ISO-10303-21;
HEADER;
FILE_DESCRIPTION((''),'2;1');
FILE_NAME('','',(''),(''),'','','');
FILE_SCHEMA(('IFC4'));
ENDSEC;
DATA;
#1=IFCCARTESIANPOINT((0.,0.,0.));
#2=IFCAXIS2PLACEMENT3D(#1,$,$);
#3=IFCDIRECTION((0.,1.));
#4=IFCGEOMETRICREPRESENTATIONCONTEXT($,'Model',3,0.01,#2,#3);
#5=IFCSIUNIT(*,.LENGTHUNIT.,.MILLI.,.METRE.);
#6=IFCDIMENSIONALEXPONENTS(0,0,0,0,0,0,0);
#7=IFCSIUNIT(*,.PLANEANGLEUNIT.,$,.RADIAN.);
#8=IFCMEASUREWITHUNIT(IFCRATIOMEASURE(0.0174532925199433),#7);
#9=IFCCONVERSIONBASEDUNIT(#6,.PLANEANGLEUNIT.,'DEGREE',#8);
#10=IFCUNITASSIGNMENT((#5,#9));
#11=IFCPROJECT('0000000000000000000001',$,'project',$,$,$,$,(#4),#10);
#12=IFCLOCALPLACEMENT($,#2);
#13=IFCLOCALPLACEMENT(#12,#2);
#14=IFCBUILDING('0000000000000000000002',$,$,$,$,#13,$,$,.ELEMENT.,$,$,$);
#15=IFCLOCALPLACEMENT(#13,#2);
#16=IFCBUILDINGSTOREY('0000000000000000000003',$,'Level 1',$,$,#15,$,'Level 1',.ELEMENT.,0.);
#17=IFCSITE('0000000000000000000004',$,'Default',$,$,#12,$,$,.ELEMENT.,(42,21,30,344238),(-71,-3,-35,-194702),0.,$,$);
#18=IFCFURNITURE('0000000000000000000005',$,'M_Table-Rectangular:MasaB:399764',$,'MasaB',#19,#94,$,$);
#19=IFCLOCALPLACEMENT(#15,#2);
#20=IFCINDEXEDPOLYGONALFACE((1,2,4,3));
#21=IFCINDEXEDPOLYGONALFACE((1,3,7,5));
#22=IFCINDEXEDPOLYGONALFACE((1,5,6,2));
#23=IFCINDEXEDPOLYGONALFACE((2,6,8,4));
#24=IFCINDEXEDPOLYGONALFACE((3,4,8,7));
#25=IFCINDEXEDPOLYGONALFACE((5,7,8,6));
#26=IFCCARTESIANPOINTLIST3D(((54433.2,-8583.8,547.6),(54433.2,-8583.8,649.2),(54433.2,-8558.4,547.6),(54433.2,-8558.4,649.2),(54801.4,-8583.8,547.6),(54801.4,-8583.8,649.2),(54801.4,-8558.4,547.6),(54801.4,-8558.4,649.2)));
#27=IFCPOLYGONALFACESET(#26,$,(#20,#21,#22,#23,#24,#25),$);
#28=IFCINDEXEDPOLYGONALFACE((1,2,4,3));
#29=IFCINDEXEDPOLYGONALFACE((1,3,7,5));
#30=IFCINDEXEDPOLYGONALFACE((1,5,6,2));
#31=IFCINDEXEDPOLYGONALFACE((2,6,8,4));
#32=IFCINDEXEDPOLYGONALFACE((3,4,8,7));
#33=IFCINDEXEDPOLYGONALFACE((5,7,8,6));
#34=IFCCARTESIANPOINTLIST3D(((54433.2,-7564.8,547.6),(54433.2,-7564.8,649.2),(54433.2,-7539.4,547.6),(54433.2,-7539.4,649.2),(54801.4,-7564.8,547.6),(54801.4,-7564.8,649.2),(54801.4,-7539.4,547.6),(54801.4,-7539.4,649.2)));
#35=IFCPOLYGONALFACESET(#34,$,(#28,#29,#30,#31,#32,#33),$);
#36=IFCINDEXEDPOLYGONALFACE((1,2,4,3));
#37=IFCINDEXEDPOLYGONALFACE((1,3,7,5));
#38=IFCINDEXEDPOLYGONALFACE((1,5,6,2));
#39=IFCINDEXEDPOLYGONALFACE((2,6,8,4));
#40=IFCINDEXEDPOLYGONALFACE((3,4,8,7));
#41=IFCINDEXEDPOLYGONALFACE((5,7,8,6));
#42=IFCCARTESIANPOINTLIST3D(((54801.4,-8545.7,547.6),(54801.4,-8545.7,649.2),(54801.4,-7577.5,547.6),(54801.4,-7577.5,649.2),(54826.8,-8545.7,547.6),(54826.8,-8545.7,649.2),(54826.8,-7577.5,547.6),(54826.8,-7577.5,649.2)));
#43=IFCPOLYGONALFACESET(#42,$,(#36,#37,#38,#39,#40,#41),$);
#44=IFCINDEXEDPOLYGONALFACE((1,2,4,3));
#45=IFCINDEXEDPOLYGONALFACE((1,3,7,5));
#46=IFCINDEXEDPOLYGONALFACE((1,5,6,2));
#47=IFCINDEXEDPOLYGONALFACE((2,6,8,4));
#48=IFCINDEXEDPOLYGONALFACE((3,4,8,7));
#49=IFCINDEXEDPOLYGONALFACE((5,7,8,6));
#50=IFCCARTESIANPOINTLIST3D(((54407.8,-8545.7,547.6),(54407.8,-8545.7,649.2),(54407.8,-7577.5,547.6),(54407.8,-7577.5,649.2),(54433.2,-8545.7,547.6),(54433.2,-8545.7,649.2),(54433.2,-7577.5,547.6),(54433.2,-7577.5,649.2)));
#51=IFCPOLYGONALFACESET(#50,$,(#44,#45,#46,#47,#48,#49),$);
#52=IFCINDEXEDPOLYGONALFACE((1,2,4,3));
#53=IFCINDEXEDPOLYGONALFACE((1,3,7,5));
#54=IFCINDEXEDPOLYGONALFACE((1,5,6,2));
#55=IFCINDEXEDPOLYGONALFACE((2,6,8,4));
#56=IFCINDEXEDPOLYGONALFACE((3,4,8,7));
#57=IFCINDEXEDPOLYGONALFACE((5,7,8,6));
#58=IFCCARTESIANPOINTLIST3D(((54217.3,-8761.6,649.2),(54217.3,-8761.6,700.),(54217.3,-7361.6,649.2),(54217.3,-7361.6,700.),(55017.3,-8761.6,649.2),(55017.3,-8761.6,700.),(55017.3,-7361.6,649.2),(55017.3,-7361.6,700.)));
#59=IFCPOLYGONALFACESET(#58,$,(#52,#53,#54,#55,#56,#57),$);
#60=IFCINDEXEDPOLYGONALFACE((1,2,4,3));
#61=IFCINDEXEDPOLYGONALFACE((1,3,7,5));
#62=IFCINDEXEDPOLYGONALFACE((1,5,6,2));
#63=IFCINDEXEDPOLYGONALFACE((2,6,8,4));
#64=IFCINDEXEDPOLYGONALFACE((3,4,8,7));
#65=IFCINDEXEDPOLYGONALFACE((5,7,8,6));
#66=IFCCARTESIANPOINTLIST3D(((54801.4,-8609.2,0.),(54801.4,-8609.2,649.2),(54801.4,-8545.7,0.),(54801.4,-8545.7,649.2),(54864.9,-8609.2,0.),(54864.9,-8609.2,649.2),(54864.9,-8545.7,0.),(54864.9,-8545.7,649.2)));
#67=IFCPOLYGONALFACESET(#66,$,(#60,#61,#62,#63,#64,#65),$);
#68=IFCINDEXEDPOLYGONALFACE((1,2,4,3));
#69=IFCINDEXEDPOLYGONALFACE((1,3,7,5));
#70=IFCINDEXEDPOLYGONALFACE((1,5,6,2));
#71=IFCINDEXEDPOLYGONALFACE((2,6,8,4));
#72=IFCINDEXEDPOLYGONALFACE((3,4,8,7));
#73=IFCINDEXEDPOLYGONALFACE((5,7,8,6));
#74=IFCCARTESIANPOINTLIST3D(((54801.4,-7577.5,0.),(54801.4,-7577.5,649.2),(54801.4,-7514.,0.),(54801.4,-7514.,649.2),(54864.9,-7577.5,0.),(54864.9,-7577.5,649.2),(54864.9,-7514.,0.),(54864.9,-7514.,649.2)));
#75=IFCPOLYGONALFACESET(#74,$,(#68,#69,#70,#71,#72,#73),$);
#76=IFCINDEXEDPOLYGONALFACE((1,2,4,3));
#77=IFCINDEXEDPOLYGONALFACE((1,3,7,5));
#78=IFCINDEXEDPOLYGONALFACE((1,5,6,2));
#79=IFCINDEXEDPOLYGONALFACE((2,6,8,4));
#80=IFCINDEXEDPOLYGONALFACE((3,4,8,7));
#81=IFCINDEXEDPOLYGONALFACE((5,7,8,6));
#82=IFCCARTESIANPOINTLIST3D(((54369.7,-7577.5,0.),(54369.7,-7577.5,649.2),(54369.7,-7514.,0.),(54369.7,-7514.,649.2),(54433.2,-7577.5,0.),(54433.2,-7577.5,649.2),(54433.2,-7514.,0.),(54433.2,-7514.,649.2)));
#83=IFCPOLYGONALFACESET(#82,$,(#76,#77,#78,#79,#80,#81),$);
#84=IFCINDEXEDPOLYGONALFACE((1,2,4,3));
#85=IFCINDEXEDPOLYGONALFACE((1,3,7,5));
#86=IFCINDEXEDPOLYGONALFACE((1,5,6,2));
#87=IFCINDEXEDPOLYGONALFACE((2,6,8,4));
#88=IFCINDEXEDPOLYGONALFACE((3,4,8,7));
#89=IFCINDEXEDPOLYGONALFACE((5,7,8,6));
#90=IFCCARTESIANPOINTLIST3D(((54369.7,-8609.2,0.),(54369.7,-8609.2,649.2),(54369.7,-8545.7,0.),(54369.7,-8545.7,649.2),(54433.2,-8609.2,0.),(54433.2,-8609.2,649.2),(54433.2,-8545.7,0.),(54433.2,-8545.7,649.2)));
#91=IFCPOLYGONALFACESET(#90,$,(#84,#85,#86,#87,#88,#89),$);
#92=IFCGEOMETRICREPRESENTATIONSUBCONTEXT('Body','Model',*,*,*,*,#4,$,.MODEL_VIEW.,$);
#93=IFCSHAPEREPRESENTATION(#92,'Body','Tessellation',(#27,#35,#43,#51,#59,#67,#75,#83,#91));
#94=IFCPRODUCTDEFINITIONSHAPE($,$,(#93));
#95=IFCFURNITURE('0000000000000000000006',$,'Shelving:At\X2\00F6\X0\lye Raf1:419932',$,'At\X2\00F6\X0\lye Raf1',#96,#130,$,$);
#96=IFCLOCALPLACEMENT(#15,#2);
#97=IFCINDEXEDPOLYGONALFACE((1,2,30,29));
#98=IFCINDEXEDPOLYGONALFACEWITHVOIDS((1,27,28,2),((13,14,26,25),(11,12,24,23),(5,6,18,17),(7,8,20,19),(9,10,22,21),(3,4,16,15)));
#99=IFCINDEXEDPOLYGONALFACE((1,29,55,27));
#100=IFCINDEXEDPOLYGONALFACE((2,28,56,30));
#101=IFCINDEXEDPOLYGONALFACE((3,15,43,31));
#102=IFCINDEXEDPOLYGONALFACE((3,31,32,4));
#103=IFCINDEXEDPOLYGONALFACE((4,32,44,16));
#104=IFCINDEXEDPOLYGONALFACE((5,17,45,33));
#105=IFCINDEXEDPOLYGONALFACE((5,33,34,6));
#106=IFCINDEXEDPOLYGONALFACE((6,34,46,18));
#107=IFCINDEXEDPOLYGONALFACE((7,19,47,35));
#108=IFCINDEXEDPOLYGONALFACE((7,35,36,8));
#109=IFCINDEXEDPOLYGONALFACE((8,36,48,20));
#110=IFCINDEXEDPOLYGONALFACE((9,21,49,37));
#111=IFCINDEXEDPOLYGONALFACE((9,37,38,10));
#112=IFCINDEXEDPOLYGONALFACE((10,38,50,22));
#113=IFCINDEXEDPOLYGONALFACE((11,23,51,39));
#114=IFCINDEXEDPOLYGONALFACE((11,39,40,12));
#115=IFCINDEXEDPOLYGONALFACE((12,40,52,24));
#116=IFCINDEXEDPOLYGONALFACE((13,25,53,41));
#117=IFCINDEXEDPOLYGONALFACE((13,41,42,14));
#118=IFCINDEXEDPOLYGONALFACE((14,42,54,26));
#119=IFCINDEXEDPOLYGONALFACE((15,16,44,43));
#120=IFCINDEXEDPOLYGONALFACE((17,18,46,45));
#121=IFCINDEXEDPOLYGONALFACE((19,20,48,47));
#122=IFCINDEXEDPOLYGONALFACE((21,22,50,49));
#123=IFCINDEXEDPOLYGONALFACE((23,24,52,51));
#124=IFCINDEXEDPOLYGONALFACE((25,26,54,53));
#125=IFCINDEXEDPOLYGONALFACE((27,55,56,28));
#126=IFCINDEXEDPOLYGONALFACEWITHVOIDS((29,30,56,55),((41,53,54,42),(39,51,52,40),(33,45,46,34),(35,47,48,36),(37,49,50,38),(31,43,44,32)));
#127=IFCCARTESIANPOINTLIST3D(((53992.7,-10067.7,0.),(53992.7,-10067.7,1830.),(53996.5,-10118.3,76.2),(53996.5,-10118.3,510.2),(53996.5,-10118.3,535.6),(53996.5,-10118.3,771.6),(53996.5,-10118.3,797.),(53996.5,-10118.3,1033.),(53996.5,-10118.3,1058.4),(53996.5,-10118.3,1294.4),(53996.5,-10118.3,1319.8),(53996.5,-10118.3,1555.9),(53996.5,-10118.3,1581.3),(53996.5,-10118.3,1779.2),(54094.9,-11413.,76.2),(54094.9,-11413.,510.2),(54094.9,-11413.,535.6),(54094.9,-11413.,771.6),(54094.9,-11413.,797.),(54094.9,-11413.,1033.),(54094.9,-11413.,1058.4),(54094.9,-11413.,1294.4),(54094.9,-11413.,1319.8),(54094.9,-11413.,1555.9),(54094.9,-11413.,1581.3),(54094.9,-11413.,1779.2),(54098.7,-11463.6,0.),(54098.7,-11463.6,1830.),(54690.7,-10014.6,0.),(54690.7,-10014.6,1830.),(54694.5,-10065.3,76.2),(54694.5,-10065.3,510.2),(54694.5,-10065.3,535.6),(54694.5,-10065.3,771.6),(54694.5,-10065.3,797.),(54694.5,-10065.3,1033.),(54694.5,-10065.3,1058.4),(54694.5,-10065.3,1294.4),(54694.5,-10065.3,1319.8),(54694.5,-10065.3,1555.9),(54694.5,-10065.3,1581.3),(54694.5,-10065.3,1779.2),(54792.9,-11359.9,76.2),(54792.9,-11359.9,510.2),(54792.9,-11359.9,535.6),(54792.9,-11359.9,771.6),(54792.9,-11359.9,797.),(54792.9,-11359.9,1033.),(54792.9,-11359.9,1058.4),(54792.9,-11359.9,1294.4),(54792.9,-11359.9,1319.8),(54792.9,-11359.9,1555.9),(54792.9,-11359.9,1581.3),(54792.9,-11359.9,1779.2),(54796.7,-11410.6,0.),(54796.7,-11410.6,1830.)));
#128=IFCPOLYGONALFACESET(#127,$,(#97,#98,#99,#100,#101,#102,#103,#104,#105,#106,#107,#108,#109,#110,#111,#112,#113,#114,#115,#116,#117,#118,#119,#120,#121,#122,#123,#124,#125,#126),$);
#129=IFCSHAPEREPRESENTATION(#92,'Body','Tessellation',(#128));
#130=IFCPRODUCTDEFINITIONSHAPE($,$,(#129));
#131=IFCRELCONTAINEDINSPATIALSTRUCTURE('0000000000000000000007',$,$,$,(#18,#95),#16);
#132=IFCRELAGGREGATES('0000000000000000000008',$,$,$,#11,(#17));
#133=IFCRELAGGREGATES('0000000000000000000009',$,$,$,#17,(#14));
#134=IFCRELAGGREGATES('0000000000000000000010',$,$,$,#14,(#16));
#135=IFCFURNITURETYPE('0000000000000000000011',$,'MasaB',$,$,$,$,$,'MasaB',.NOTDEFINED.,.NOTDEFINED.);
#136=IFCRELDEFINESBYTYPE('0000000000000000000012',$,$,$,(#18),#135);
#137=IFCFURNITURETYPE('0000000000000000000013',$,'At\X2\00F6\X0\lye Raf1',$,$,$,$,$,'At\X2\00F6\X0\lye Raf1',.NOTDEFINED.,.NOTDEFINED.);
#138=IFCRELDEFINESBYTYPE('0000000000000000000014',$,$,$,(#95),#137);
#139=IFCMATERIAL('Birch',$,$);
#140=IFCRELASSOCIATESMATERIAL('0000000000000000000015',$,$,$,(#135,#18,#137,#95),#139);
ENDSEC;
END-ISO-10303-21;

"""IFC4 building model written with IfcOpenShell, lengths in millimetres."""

from ifc_helpers import new_model, entity, si_unit, converted_unit, direction, frame, frame_2d, origin, origin_2d_with_axis, place, context, subcontext, project, spatial, polyline, rectangle, outline, extrude, source, transform, mapped, material, type_object, type_shapes, element, save


model = new_model("IFC4")

# Units and contexts
model_context = context("Model", 3, precision=0.01, world=origin(), true_north=direction((0.0, 1.0)))
body_context = subcontext(model_context, "Body", "Model", "MODEL_VIEW")
ifc_project = project(units=[si_unit("LENGTHUNIT", "METRE", prefix="MILLI"), converted_unit("PLANEANGLEUNIT", "DEGREE", entity("IfcRatioMeasure", 0.0174532925199433), si_unit("PLANEANGLEUNIT", "RADIAN"), dimensions=[0, 0, 0, 0, 0, 0, 0])], contexts=[model_context])

# Site, building, storey
site_placement = place(None, origin())
site = spatial("IfcSite", under=ifc_project, at=site_placement, Name="Default", CompositionType="ELEMENT", RefLatitude=(42, 21, 30, 344238), RefLongitude=(-71, -3, -35, -194702), RefElevation=0.0)
building_placement = place(site_placement, origin())
building = spatial("IfcBuilding", under=site, at=building_placement, CompositionType="ELEMENT")
storey_placement = place(building_placement, origin())
storey = spatial("IfcBuildingStorey", under=building, at=storey_placement, Name="Level 1", LongName="Level 1", CompositionType="ELEMENT", Elevation=0.0)

# Furniture
ifc_material_1 = material(Name="Birch")
furniture_type_1 = type_object("IfcFurnitureType", Name="MasaB", ElementType="MasaB", AssemblyPlace="NOTDEFINED", PredefinedType="NOTDEFINED", material=ifc_material_1)
shared_shape_1 = source(origin(), body_context, "Body", "SweptSolid", [
    extrude(rectangle(XDim=25.4, YDim=368.2, at=origin_2d_with_axis()), frame((509.5, 0.0, 547.6)), (0.0, 0.0, 1.0), 101.6),
    extrude(rectangle(XDim=368.2, YDim=25.4, at=origin_2d_with_axis()), frame((-509.5, 0.0, 547.6), z_axis=(0.0, 0.0, 1.0), x_axis=(0.0, 1.0, 0.0)), (0.0, 0.0, 1.0), 101.6),
    extrude(rectangle(XDim=968.2, YDim=25.4, at=frame_2d((0.0, 0.0), x_axis=(1.0, 0.0))), frame((0.0, 196.8, 547.6), z_axis=(0.0, 0.0, 1.0), x_axis=(-1.0, 0.0, 0.0)), (0.0, 0.0, 1.0), 101.6),
    extrude(rectangle(XDim=25.4, YDim=968.2, at=origin_2d_with_axis()), frame((0.0, -196.8, 547.6), z_axis=(0.0, 0.0, 1.0), x_axis=(0.0, 1.0, 0.0)), (0.0, 0.0, 1.0), 101.6),
    extrude(rectangle(XDim=1400.0, YDim=800.0, at=origin_2d_with_axis()), frame((0.0, 0.0, 649.2), z_axis=(0.0, 0.0, 1.0), x_axis=(-1.0, 0.0, 0.0)), (0.0, 0.0, 1.0), 50.8),
    extrude(rectangle(XDim=63.5, YDim=63.5, at=origin_2d_with_axis()), frame((515.9, 215.9, 0.0), z_axis=(0.0, 0.0, 1.0), x_axis=(0.0, -1.0, 0.0)), (0.0, 0.0, 1.0), 649.2),
    extrude(rectangle(XDim=63.5, YDim=63.5, at=origin_2d_with_axis()), frame((-515.9, 215.9, 0.0), z_axis=(0.0, 0.0, 1.0), x_axis=(-1.0, 0.0, 0.0)), (0.0, 0.0, 1.0), 649.2),
    extrude(rectangle(XDim=63.5, YDim=63.5, at=origin_2d_with_axis()), frame((-515.9, -215.9, 0.0), z_axis=(0.0, 0.0, 1.0), x_axis=(0.0, 1.0, 0.0)), (0.0, 0.0, 1.0), 649.2),
    extrude(rectangle(XDim=63.5, YDim=63.5, at=frame_2d((0.0, 0.0), x_axis=(1.0, 0.0))), frame((515.9, -215.9, 0.0)), (0.0, 0.0, 1.0), 649.2),
])
type_shapes(furniture_type_1, [shared_shape_1])
furniture_1_placement = place(storey_placement, frame((54617.3, -8061.6, 0.0), z_axis=(0.0, 0.0, 1.0), x_axis=(0.0, -1.0, 0.0)))
element("IfcFurniture", 1, at=furniture_1_placement, inside=storey, type_object=furniture_type_1, material=ifc_material_1, Name="M_Table-Rectangular:MasaB:399764", ObjectType="MasaB", context=body_context, shape_type="MappedRepresentation", body=[
    mapped(shared_shape_1, transform((0.0, 0.0, 0.0), scale=1.0)),
])

# Furniture
furniture_type_2 = type_object("IfcFurnitureType", Name="Atölye Raf1", ElementType="Atölye Raf1", AssemblyPlace="NOTDEFINED", PredefinedType="NOTDEFINED", material=ifc_material_1)
shared_shape_2 = source(origin(), body_context, "Body", "SweptSolid", [
    extrude(outline(polyline([(-700.0, -915.0), (700.0, -915.0), (700.0, 915.0), (-700.0, 915.0), (-700.0, -915.0)]), holes=[polyline([(-649.2, 864.2), (649.2, 864.2), (649.2, 666.3), (-649.2, 666.3), (-649.2, 864.2)]), polyline([(-649.2, -838.8), (-649.2, -404.8), (649.2, -404.8), (649.2, -838.8), (-649.2, -838.8)]), polyline([(649.2, 143.4), (-649.2, 143.4), (-649.2, 379.4), (649.2, 379.4), (649.2, 143.4)]), polyline([(-649.2, 640.9), (649.2, 640.9), (649.2, 404.8), (-649.2, 404.8), (-649.2, 640.9)]), polyline([(-649.2, 118.0), (649.2, 118.0), (649.2, -118.0), (-649.2, -118.0), (-649.2, 118.0)]), polyline([(-649.2, -143.4), (649.2, -143.4), (649.2, -379.4), (-649.2, -379.4), (-649.2, -143.4)])]), frame((0.0, -654.8, 915.0), z_axis=(0.0, 1.0, 0.0), x_axis=(-1.0, 0.0, 0.0)), (0.0, 0.0, 1.0), 700.0),
])
type_shapes(furniture_type_2, [shared_shape_2])
furniture_2_placement = place(storey_placement, frame((54698.6, -10716.0, 0.0), z_axis=(0.0, 0.0, 1.0), x_axis=(0.075759, -0.997126, 0.0)))
element("IfcFurniture", 2, at=furniture_2_placement, inside=storey, type_object=furniture_type_2, material=ifc_material_1, Name="Shelving:Atölye Raf1:419932", ObjectType="Atölye Raf1", context=body_context, shape_type="MappedRepresentation", body=[
    mapped(shared_shape_2, transform((0.0, 0.0, 0.0), scale=1.0)),
])

save(model, "model.ifc")
